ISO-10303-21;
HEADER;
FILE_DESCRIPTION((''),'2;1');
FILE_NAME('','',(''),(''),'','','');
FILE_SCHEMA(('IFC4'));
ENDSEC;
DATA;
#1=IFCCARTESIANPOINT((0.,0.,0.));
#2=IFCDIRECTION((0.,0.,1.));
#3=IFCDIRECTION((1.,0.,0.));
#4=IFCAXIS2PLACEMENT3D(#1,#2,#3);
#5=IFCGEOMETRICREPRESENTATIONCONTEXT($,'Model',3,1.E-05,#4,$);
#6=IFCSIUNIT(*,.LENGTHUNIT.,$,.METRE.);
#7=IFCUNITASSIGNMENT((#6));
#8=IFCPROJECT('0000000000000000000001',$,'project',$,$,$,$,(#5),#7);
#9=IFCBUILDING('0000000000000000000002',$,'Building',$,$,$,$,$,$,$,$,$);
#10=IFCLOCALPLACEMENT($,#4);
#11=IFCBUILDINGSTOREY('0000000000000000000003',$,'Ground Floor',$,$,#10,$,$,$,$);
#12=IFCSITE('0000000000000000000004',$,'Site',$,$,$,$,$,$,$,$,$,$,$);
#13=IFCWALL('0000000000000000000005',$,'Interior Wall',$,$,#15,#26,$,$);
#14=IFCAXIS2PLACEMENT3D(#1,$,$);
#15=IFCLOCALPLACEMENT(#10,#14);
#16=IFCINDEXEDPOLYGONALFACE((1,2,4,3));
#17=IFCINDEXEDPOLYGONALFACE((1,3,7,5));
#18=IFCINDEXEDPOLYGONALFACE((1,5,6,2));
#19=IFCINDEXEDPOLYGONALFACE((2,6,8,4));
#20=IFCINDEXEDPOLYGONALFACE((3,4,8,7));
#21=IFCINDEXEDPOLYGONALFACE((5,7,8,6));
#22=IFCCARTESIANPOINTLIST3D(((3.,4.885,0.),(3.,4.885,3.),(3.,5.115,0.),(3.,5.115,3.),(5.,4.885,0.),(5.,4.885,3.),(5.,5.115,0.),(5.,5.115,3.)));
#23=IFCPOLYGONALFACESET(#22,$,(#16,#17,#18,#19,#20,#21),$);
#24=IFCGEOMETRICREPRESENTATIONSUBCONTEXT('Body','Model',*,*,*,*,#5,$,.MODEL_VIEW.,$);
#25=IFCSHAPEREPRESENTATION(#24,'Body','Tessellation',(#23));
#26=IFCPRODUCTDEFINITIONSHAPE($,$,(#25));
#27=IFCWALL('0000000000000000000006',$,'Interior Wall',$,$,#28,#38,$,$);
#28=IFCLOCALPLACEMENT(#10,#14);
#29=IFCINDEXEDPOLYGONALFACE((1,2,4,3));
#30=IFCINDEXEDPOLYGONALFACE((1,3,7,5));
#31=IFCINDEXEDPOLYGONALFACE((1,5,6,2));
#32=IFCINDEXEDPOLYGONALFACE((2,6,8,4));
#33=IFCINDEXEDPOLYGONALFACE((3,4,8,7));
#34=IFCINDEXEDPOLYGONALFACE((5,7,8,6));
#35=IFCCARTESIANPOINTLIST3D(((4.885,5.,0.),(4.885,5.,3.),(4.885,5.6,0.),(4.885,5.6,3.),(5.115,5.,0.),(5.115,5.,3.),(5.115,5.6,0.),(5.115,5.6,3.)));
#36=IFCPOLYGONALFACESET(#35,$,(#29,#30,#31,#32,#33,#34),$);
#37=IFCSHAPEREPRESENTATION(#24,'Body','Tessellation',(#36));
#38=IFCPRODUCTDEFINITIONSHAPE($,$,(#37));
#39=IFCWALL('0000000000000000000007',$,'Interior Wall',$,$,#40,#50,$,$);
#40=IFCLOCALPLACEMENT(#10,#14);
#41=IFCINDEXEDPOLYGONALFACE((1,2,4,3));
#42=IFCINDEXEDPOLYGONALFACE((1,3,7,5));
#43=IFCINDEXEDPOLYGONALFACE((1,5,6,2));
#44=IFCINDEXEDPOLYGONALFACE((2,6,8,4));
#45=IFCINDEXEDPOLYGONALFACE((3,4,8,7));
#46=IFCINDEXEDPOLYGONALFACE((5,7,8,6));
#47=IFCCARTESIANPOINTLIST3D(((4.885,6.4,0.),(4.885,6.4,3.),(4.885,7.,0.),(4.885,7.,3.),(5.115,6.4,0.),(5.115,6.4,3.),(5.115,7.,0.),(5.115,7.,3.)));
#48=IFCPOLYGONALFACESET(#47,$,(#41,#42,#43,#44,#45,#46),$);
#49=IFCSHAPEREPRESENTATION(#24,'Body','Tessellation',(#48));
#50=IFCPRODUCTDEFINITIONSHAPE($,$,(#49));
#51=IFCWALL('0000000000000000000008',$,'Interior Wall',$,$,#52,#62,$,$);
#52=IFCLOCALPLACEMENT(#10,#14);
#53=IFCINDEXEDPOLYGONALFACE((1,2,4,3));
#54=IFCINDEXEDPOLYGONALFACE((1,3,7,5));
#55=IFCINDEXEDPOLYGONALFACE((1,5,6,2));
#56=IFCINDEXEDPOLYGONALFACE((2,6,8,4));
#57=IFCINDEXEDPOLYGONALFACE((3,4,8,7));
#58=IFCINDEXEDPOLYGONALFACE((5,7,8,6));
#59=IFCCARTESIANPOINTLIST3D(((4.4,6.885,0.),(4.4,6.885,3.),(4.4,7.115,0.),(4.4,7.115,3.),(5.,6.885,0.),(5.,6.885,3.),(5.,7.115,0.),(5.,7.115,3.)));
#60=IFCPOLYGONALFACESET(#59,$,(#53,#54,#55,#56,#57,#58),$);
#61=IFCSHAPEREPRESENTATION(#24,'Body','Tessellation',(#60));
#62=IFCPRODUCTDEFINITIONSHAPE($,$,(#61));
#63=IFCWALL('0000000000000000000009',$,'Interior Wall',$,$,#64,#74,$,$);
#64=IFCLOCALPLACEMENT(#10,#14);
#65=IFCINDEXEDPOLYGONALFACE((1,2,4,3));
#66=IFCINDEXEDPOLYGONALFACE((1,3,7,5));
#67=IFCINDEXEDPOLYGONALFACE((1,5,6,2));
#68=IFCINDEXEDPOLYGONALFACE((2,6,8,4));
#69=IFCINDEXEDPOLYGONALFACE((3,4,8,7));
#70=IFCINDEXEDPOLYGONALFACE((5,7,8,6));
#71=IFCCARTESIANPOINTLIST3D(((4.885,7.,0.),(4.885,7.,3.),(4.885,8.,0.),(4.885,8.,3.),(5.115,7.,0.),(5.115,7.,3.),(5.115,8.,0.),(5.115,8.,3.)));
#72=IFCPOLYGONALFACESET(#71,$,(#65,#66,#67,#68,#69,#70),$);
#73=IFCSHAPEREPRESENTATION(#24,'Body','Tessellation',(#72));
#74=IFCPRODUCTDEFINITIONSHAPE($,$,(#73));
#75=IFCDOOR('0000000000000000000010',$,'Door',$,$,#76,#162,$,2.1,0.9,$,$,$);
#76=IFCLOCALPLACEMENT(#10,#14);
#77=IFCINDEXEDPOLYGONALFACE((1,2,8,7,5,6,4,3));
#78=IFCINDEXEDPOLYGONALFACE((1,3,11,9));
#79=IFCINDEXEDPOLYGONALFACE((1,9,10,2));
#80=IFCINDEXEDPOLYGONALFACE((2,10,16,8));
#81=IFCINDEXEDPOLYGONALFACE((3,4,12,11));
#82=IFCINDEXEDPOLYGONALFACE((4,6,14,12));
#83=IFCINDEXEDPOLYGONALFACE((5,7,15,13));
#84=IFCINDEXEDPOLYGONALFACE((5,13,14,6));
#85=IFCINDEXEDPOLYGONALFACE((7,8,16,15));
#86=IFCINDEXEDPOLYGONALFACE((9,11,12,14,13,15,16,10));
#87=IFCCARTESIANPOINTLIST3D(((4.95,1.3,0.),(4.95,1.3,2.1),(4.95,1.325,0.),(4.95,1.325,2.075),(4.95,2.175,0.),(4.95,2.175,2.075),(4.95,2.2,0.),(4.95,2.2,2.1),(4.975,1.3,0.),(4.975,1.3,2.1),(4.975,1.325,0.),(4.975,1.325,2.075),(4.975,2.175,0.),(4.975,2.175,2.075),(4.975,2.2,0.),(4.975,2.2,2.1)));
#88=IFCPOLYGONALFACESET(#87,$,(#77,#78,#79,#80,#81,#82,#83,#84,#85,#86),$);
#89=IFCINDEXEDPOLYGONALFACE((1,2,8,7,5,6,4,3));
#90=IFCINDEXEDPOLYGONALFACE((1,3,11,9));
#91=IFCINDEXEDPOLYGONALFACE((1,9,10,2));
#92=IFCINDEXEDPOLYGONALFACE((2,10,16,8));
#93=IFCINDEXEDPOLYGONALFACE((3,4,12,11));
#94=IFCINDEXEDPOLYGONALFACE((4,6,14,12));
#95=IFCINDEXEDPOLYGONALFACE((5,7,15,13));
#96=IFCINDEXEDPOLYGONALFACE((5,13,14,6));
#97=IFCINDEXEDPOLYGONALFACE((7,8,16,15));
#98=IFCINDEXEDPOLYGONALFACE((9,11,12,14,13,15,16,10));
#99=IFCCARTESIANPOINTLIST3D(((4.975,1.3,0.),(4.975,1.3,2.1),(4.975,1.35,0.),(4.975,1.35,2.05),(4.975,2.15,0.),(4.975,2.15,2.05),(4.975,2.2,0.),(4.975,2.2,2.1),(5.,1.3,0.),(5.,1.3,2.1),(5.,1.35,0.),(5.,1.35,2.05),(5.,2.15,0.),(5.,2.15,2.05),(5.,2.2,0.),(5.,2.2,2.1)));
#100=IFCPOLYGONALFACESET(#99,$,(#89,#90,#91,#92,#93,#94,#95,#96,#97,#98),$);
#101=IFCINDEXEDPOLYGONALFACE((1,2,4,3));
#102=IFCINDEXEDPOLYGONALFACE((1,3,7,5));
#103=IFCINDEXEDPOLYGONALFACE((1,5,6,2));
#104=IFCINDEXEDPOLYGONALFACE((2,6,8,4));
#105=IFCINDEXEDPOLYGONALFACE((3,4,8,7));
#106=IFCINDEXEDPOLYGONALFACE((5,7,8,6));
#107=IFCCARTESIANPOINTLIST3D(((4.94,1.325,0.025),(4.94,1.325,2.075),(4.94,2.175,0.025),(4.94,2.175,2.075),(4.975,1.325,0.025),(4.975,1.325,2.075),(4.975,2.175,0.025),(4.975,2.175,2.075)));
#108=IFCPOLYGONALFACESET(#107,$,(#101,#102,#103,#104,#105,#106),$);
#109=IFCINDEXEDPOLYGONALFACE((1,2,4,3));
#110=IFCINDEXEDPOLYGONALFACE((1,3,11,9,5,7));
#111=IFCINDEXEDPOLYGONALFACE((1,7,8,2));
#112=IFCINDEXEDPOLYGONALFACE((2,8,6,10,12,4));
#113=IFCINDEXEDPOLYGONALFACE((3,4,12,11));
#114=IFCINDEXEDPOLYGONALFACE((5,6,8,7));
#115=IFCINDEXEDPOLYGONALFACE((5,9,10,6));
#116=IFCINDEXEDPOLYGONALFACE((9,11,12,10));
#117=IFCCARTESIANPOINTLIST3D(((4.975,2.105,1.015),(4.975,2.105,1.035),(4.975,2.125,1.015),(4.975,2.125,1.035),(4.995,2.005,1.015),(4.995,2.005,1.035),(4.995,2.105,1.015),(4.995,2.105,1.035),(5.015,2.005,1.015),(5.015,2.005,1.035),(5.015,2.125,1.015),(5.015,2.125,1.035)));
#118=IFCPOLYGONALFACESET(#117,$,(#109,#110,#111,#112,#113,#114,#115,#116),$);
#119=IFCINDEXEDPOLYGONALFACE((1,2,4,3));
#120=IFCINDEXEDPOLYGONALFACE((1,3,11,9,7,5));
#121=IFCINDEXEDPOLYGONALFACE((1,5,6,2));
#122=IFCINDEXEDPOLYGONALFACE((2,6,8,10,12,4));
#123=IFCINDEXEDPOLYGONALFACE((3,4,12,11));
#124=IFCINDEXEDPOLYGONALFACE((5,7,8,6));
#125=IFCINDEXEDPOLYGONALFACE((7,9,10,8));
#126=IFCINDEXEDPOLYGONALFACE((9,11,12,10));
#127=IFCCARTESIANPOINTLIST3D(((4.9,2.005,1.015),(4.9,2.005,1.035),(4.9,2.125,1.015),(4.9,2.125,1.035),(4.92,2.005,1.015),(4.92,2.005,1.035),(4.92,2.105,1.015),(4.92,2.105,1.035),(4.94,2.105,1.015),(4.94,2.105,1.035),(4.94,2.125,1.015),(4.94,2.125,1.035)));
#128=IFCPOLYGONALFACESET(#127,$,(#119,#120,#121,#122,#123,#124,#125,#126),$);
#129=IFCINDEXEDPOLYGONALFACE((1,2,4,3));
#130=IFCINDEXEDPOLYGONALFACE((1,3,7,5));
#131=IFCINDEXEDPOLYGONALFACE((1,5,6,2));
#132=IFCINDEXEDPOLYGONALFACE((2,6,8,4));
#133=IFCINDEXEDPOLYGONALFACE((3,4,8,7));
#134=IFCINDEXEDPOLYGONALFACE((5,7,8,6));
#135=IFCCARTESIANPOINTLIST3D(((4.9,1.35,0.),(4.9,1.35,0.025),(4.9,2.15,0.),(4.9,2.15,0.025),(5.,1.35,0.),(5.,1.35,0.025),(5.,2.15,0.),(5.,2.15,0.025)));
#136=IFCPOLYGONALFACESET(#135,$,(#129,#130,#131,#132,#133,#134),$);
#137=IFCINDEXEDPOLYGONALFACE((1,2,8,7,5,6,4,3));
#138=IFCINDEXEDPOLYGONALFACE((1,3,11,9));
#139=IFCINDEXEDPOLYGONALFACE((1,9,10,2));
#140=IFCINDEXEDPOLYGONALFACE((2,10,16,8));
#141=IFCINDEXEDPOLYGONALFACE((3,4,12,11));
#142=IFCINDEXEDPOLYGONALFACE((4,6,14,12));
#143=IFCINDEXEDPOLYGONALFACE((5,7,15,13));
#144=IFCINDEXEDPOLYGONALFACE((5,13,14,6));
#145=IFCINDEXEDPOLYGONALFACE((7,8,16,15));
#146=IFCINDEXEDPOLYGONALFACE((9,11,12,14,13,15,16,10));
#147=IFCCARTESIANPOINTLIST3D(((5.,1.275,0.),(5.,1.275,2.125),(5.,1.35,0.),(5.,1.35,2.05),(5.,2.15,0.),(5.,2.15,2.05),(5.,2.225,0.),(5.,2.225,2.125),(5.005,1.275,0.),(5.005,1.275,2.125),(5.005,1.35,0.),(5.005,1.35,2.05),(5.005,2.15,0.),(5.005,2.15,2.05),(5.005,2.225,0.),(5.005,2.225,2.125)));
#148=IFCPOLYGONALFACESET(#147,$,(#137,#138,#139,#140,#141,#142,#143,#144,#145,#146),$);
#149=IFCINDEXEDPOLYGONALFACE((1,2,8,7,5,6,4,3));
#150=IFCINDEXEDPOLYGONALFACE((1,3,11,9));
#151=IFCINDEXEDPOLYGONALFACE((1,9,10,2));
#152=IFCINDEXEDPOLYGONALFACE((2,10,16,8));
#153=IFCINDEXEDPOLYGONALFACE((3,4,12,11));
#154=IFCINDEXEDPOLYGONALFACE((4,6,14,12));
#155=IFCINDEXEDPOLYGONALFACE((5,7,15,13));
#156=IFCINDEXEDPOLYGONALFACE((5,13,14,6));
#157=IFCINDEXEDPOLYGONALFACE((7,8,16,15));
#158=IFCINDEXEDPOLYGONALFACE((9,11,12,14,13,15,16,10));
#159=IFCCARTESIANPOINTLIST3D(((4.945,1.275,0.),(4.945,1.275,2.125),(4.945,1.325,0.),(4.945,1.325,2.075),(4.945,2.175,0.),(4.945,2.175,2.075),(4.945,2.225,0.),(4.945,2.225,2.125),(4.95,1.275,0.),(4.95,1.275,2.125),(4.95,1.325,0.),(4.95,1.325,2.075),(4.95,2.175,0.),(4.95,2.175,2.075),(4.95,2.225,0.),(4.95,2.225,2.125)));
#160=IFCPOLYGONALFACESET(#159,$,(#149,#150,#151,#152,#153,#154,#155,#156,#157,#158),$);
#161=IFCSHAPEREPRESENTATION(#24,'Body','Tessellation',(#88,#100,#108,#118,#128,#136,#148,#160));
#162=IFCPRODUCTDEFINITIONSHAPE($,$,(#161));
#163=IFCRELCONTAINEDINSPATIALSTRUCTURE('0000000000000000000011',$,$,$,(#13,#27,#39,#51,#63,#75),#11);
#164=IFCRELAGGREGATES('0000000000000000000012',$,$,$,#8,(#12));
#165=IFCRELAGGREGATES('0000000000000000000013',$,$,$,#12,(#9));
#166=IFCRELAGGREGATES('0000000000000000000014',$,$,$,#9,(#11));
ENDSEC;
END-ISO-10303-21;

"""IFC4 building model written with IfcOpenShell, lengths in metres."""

from ifc_helpers import new_model, si_unit, frame, origin_with_axes, place, context, subcontext, project, spatial, line, indexed_curve, outline, extrude, element, save


model = new_model("IFC4")

# Units and contexts
model_context = context("Model", 3, precision=1e-05, world=origin_with_axes())
body_context = subcontext(model_context, "Body", "Model", "MODEL_VIEW")
ifc_project = project(units=[si_unit("LENGTHUNIT", "METRE")], contexts=[model_context])

# Site, building, storey
site = spatial("IfcSite", under=ifc_project, Name="Site")
building = spatial("IfcBuilding", under=site, Name="Building")
storey_placement = place(None, origin_with_axes())
storey = spatial("IfcBuildingStorey", under=building, at=storey_placement, Name="Ground Floor")

# Walls
wall_1_placement = place(storey_placement, frame((5.0, 5.0, 0.0), z_axis=(0.0, 0.0, 1.0), x_axis=(-1.0, 0.0, 0.0)))
element("IfcWall", 1, at=wall_1_placement, inside=storey, Name="Interior Wall", context=body_context, shape_type="SweptSolid", body=[
    extrude(outline(indexed_curve([(0.0, 0.0), (0.0, 0.23), (2.0, 0.23), (2.0, 0.0), (0.0, 0.0)], self_intersect=False)), frame((0.0, -0.115, 0.0), z_axis=(0.0, 0.0, 1.0), x_axis=(1.0, 0.0, 0.0)), (0.0, 0.0, 1.0), 3.0),
])
for number, where, z_axis, x_axis, name in (
    (2, (5.0, 5.0, 0.0), (0.0, 0.0, 1.0), (0.0, 1.0, 0.0), "Interior Wall"),
    (3, (5.0, 6.4, 0.0), (0.0, 0.0, 1.0), (0.0, 1.0, 0.0), "Interior Wall"),
    (4, (5.0, 7.0, 0.0), (0.0, 0.0, 1.0), (-1.0, 0.0, 0.0), "Interior Wall"),
):
    element("IfcWall", number, at=place(storey_placement, frame(where, z_axis=z_axis, x_axis=x_axis)), inside=storey, Name=name, context=body_context, shape_type="SweptSolid", body=[
        extrude(outline(indexed_curve([(0.0, 0.0), (0.0, 0.23), (0.6, 0.23), (0.6, 0.0), (0.0, 0.0)], self_intersect=False)), frame((0.0, -0.115, 0.0), z_axis=(0.0, 0.0, 1.0), x_axis=(1.0, 0.0, 0.0)), (0.0, 0.0, 1.0), 3.0),
    ])
wall_2_placement = place(storey_placement, frame((5.0, 8.0, 0.0), z_axis=(0.0, 0.0, 1.0), x_axis=(0.0, -1.0, 0.0)))
element("IfcWall", 5, at=wall_2_placement, inside=storey, Name="Interior Wall", context=body_context, shape_type="SweptSolid", body=[
    extrude(outline(indexed_curve([(0.0, 0.0), (0.0, 0.23), (1.0, 0.23), (1.0, 0.0), (0.0, 0.0)], self_intersect=False)), frame((0.0, -0.115, 0.0), z_axis=(0.0, 0.0, 1.0), x_axis=(1.0, 0.0, 0.0)), (0.0, 0.0, 1.0), 3.0),
])

# Door
door_1_placement = place(storey_placement, frame((5.0, 1.3, 0.0), z_axis=(0.0, 0.0, 1.0), x_axis=(0.0, 1.0, 0.0)))
element("IfcDoor", 6, at=door_1_placement, inside=storey, Name="Door", OverallHeight=2.1, OverallWidth=0.9, context=body_context, shape_type="SweptSolid", body=[
    extrude(outline(indexed_curve([(0.0, 0.0), (0.0, 2.1), (0.9, 2.1), (0.9, 0.0), (0.875, 0.0), (0.875, 2.075), (0.025, 2.075), (0.025, 0.0)], segments=[line(1, 2, 3, 4, 5, 6, 7, 8, 1)])), frame((0.0, 0.025, 0.0), z_axis=(0.0, -1.0, 0.0), x_axis=(1.0, 0.0, 0.0)), (0.0, 0.0, -1.0), 0.025),
    extrude(outline(indexed_curve([(0.0, 0.0), (0.0, 2.1), (0.9, 2.1), (0.9, 0.0), (0.85, 0.0), (0.85, 2.05), (0.05, 2.05), (0.05, 0.0)], segments=[line(1, 2, 3, 4, 5, 6, 7, 8, 1)])), frame((0.0, 0.0, 0.0), z_axis=(0.0, -1.0, 0.0), x_axis=(1.0, 0.0, 0.0)), (0.0, 0.0, -1.0), 0.025),
    extrude(outline(indexed_curve([(0.0, 0.0), (0.85, 0.0), (0.85, 0.035), (0.0, 0.035)], segments=[line(1, 2, 3, 4, 1)])), frame((0.025, 0.025, 0.025), z_axis=(0.0, 0.0, 1.0), x_axis=(1.0, 0.0, 0.0)), (0.0, 0.0, 1.0), 2.05),
    extrude(outline(indexed_curve([(0.0, 0.0), (0.0, -0.04), (-0.12, -0.04), (-0.12, -0.02), (-0.02, -0.02), (-0.02, 0.0)], segments=[line(1, 2, 3, 4, 5, 6, 1)])), frame((0.825, 0.025, 1.015), z_axis=(0.0, 0.0, 1.0), x_axis=(1.0, 0.0, 0.0)), (0.0, 0.0, 1.0), 0.02),
    extrude(outline(indexed_curve([(0.0, 0.0), (0.0, 0.04), (-0.12, 0.04), (-0.12, 0.02), (-0.02, 0.02), (-0.02, 0.0)], segments=[line(1, 2, 3, 4, 5, 6, 1)])), frame((0.825, 0.06, 1.015), z_axis=(0.0, 0.0, 1.0), x_axis=(1.0, 0.0, 0.0)), (0.0, 0.0, 1.0), 0.02),
    extrude(outline(indexed_curve([(0.0, 0.0), (0.8, 0.0), (0.8, 0.1), (0.0, 0.1)], segments=[line(1, 2, 3, 4, 1)])), frame((0.05, 0.0, 0.0), z_axis=(0.0, 0.0, 1.0), x_axis=(1.0, 0.0, 0.0)), (0.0, 0.0, 1.0), 0.025),
    extrude(outline(indexed_curve([(0.0, 0.0), (0.0, 2.125), (0.95, 2.125), (0.95, 0.0), (0.875, 0.0), (0.875, 2.05), (0.075, 2.05), (0.075, 0.0)], segments=[line(1, 2, 3, 4, 5, 6, 7, 8, 1)])), frame((-0.025, -0.005, 0.0), z_axis=(0.0, -1.0, 0.0), x_axis=(1.0, 0.0, 0.0)), (0.0, 0.0, -1.0), 0.005),
    extrude(outline(indexed_curve([(0.0, 0.0), (0.0, 2.125), (0.95, 2.125), (0.95, 0.0), (0.9, 0.0), (0.9, 2.075), (0.05, 2.075), (0.05, 0.0)], segments=[line(1, 2, 3, 4, 5, 6, 7, 8, 1)])), frame((-0.025, 0.05, 0.0), z_axis=(0.0, -1.0, 0.0), x_axis=(1.0, 0.0, 0.0)), (0.0, 0.0, -1.0), 0.005),
])

save(model, "model.ifc")
